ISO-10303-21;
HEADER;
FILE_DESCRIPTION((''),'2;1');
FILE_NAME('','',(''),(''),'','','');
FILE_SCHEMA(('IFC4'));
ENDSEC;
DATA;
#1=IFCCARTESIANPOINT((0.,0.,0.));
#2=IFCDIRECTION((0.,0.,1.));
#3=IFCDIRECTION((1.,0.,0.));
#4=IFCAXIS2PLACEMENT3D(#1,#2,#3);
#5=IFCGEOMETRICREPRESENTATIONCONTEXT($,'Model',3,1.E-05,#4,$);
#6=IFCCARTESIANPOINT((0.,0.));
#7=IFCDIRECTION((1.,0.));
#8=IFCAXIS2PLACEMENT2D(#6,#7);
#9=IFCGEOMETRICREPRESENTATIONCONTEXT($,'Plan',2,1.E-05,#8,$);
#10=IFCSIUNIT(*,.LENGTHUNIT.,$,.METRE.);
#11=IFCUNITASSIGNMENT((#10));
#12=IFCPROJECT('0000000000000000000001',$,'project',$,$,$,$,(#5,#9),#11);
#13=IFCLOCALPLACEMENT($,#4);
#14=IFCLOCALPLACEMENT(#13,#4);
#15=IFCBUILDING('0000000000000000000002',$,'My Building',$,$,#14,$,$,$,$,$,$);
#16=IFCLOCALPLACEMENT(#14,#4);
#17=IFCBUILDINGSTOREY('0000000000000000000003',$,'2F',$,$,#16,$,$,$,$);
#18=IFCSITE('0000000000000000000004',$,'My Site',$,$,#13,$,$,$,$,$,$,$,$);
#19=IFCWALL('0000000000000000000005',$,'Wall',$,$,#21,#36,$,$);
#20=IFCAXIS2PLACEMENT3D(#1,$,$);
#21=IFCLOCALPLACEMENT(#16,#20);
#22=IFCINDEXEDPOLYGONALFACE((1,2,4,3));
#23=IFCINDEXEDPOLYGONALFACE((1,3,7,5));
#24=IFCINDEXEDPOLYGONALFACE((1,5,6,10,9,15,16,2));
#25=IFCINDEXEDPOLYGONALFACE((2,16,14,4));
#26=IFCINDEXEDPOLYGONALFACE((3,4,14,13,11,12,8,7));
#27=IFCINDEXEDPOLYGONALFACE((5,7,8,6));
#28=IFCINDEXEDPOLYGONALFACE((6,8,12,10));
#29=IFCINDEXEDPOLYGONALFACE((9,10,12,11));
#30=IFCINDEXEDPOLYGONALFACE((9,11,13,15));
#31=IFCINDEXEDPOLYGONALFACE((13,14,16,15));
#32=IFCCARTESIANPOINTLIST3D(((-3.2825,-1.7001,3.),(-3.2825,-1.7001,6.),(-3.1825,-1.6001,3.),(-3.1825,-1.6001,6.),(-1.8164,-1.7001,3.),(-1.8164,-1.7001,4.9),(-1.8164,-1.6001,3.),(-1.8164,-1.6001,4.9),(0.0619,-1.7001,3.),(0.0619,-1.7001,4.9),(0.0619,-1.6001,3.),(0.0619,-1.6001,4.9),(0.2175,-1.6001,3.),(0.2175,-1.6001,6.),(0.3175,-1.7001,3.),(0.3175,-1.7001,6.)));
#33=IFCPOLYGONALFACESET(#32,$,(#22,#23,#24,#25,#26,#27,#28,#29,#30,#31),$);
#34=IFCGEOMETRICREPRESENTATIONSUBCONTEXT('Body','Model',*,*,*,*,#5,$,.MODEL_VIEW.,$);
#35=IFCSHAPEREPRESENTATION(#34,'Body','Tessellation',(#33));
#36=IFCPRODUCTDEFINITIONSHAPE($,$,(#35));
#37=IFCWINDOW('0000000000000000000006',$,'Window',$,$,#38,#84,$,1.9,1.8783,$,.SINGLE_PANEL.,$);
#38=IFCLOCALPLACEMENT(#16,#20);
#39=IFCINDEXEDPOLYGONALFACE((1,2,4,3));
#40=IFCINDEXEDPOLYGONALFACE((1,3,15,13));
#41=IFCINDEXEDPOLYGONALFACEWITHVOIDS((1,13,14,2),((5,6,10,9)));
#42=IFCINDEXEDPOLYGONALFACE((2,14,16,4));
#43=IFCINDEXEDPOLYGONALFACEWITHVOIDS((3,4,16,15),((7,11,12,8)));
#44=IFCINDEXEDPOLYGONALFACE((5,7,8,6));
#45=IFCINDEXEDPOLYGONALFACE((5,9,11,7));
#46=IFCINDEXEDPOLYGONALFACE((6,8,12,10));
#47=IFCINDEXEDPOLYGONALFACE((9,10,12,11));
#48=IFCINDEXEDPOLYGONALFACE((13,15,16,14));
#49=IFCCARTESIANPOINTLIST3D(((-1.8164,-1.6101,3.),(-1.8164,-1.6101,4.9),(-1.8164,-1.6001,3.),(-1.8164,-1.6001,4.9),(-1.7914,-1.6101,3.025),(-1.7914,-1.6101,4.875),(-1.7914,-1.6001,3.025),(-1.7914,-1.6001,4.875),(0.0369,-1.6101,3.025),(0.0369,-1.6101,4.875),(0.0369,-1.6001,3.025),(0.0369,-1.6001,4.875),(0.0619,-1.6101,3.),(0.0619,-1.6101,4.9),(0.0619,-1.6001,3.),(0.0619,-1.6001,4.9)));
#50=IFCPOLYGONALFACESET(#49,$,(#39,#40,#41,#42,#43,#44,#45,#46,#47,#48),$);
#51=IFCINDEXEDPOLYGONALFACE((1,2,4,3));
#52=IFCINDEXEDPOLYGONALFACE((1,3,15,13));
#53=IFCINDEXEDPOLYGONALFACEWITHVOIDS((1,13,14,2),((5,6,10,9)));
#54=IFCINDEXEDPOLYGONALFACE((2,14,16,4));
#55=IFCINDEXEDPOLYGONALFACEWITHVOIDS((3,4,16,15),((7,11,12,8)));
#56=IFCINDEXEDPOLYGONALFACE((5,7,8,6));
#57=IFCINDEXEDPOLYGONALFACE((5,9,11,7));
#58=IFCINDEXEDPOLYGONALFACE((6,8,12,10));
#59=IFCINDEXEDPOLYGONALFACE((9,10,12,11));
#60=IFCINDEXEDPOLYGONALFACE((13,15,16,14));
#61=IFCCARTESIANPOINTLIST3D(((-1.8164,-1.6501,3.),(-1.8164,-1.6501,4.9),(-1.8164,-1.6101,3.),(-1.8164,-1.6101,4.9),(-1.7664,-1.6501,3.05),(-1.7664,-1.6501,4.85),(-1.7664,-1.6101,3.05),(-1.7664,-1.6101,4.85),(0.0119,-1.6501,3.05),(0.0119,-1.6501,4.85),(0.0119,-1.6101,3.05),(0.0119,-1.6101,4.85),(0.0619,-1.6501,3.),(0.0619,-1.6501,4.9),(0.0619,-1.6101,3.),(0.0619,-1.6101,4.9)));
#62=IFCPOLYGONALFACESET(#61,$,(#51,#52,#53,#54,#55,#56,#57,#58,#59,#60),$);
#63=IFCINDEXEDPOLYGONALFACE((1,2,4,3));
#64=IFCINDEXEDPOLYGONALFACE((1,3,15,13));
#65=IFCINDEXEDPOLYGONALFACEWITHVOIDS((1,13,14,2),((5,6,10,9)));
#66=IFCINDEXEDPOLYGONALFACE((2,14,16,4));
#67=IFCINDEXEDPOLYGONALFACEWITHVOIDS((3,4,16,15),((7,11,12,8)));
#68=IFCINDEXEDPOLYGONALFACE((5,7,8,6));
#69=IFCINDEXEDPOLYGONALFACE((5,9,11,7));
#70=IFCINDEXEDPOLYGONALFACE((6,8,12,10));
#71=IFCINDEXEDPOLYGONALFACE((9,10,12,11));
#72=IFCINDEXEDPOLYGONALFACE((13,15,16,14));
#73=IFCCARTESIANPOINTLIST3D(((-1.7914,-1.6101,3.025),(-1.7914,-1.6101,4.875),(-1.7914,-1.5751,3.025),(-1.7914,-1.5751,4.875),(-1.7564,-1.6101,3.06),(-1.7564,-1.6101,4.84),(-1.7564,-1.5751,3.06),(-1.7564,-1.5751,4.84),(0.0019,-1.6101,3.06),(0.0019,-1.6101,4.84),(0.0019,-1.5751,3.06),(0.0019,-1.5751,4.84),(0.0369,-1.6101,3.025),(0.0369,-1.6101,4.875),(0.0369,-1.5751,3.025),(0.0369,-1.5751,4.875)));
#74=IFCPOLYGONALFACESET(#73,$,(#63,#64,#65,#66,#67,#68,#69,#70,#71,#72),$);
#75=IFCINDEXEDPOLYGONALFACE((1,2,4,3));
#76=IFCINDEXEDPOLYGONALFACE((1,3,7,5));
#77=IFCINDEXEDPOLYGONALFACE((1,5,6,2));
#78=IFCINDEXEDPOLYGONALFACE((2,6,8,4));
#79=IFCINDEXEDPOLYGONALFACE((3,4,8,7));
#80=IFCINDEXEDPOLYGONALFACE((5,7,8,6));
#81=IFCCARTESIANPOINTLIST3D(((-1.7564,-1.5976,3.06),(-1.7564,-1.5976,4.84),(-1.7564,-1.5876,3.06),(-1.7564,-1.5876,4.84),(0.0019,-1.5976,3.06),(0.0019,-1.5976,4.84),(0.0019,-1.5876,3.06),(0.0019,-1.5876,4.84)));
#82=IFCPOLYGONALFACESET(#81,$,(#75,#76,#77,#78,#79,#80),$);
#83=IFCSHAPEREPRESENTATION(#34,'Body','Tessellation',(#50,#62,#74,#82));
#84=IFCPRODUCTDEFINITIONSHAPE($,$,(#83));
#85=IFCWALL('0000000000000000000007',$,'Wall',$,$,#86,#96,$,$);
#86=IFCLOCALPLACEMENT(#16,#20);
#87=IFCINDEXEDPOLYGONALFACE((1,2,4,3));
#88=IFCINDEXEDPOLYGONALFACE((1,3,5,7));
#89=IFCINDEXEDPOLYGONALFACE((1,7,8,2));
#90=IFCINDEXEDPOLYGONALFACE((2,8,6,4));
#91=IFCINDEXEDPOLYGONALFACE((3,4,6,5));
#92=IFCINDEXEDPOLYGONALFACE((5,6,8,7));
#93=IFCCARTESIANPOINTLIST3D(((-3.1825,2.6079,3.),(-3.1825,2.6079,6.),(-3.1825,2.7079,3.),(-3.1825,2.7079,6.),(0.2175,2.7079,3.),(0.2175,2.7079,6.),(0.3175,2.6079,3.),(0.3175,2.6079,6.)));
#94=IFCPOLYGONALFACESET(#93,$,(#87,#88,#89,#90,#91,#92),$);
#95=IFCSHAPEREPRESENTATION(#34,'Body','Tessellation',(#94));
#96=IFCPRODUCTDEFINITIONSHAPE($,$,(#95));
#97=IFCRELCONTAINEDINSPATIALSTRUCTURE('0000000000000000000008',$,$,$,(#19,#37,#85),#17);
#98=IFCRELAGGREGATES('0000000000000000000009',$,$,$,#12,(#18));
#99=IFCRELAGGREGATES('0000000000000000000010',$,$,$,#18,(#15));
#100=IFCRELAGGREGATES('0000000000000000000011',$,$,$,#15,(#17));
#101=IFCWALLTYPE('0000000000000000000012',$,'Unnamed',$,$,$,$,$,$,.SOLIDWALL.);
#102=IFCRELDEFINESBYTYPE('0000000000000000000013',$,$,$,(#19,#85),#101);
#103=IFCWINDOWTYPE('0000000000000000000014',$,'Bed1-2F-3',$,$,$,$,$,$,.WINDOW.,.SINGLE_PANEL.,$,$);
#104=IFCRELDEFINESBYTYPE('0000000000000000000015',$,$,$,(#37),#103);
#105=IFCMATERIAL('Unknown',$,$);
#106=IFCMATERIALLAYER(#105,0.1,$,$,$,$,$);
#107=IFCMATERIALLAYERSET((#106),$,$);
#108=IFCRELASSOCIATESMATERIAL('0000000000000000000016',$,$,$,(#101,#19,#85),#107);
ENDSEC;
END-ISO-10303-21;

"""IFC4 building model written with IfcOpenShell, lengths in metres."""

from ifc_helpers import new_model, entity, si_unit, frame, origin_with_axes, origin_2d_with_axis, place, context, subcontext, project, spatial, line, indexed_curve, outline, extrude, shape, source, transform, mapped, material, layer, layer_set, layer_usage, type_object, type_shapes, element, fill, save


model = new_model("IFC4")

# Units and contexts
model_context = context("Model", 3, precision=1e-05, world=origin_with_axes())
plan_context = context("Plan", 2, precision=1e-05, world=origin_2d_with_axis())
body_context_1 = subcontext(model_context, "Body", "Model", "MODEL_VIEW")
body_context_2 = subcontext(plan_context, "Body", "Plan", "PLAN_VIEW")
ifc_project = project(units=[si_unit("LENGTHUNIT", "METRE")], contexts=[model_context, plan_context])

# Site, building, storey
site_placement = place(None, origin_with_axes())
site = spatial("IfcSite", under=ifc_project, at=site_placement, Name="My Site")
building_placement = place(site_placement, origin_with_axes())
building = spatial("IfcBuilding", under=site, at=building_placement, Name="My Building")
storey_placement = place(building_placement, origin_with_axes())
storey = spatial("IfcBuildingStorey", under=building, at=storey_placement, Name="2F")

# Shared definitions
ifc_material = material(Name="Unknown")

# Shared definitions
ifc_layer = layer(ifc_material, 0.1)
ifc_layer_set = layer_set([ifc_layer])
wall_type = type_object("IfcWallType", Name="Unnamed", PredefinedType="SOLIDWALL", material=ifc_layer_set)

# Wall, opening, window
ifc_layer_usage_1 = layer_usage(ifc_layer_set, "AXIS2", "POSITIVE", 0.0)
wall_1_placement = place(storey_placement, frame((-3.1825, -1.7001, 3.0), z_axis=(0.0, 0.0, 1.0), x_axis=(1.0, 0.0, 0.0)))
wall_1 = element("IfcWall", 1, at=wall_1_placement, inside=storey, type_object=wall_type, material=ifc_layer_usage_1, Name="Wall", context=body_context_1, shape_type="SweptSolid", body=[
    extrude(outline(indexed_curve([(-0.1, 0.0), (0.0, 0.1), (3.4, 0.1), (3.5, 0.0)], segments=[line(1, 2, 3, 4, 1)])), origin_with_axes(), (0.0, 0.0, 1.0), 3.0),
])
shared_shape_1 = source(origin_with_axes(), body_context_1, "Body", "SweptSolid", [
    extrude(outline(indexed_curve([(0.0, 0.0), (1.8783, 0.0), (1.8783, 1.9), (0.0, 1.9)], segments=[line(1, 2, 3, 4, 1)])), frame((0.0, -0.6, 0.0), z_axis=(0.0, -1.0, 0.0), x_axis=(1.0, 0.0, 0.0)), (0.0, 0.0, -1.0), 1.2),
])
opening_1_placement = place(wall_1_placement, frame((1.3661, 0.0, 0.0), z_axis=(0.0, 0.0, 1.0), x_axis=(1.0, 0.0, 0.0)))
opening_1 = element("IfcOpeningElement", 2, at=opening_1_placement, cuts=wall_1, PredefinedType="OPENING", context=body_context_1, shape_type="MappedRepresentation", body=[
    mapped(shared_shape_1, transform((0.0, 0.0, 0.0), x_axis=(1.0, 0.0, 0.0), y_axis=(0.0, 1.0, 0.0), z_axis=(0.0, 0.0, 1.0), scale=1.0)),
])
window_type_1 = type_object("IfcWindowType", Name="Bed1-2F-3", PartitioningType="SINGLE_PANEL", PredefinedType="WINDOW")
shared_shape_2 = source(origin_with_axes(), body_context_1, "Body", "SweptSolid", [
    extrude(outline(indexed_curve([(0.0, 0.0), (1.8783, 0.0), (1.8783, 1.9), (0.0, 1.9)], segments=[line(1, 2, 3, 4, 1)]), holes=[indexed_curve([(0.025, 0.025), (1.8533, 0.025), (1.8533, 1.875), (0.025, 1.875)], segments=[line(1, 2, 3, 4, 1)])]), frame((0.0, 0.09, 0.0), z_axis=(0.0, -1.0, 0.0), x_axis=(1.0, 0.0, 0.0)), (0.0, 0.0, -1.0), 0.01),
    extrude(outline(indexed_curve([(0.0, 0.0), (1.8783, 0.0), (1.8783, 1.9), (0.0, 1.9)], segments=[line(1, 2, 3, 4, 1)]), holes=[indexed_curve([(0.05, 0.05), (1.8283, 0.05), (1.8283, 1.85), (0.05, 1.85)], segments=[line(1, 2, 3, 4, 1)])]), frame((0.0, 0.05, 0.0), z_axis=(0.0, -1.0, 0.0), x_axis=(1.0, 0.0, 0.0)), (0.0, 0.0, -1.0), 0.04),
    extrude(outline(indexed_curve([(0.0, 0.0), (1.8283, 0.0), (1.8283, 1.85), (0.0, 1.85)], segments=[line(1, 2, 3, 4, 1)]), holes=[indexed_curve([(0.035, 0.035), (1.7933, 0.035), (1.7933, 1.815), (0.035, 1.815)], segments=[line(1, 2, 3, 4, 1)])]), frame((0.025, 0.09, 0.025), z_axis=(0.0, -1.0, 0.0), x_axis=(1.0, 0.0, 0.0)), (0.0, 0.0, -1.0), 0.035),
    extrude(outline(indexed_curve([(0.035, 0.035), (1.7933, 0.035), (1.7933, 1.815), (0.035, 1.815)], segments=[line(1, 2, 3, 4, 1)])), frame((0.025, 0.1025, 0.025), z_axis=(0.0, -1.0, 0.0), x_axis=(1.0, 0.0, 0.0)), (0.0, 0.0, -1.0), 0.01),
])
shared_shape_3 = source(origin_with_axes(), body_context_2, "Body", "Curve2D", [
    entity("IfcIndexedPolyCurve", entity("IfcCartesianPointList2D", [[0.05, 0.05], [1.8283, 0.05]])),
    entity("IfcIndexedPolyCurve", entity("IfcCartesianPointList2D", [[0.0, 0.1], [0.025, 0.1], [0.025, 0.09], [0.05, 0.09], [0.05, 0.05], [0.0, 0.05]]), [entity("IfcLineIndex", [1, 2, 3, 4, 5, 6, 1])]),
    entity("IfcIndexedPolyCurve", entity("IfcCartesianPointList2D", [[1.8783, 0.1], [1.8533, 0.1], [1.8533, 0.09], [1.8283, 0.09], [1.8283, 0.05], [1.8783, 0.05]]), [entity("IfcLineIndex", [1, 2, 3, 4, 5, 6, 1])]),
    entity("IfcIndexedPolyCurve", entity("IfcCartesianPointList2D", [[0.025, 0.09], [0.06, 0.09], [0.06, 0.125], [0.025, 0.125]]), [entity("IfcLineIndex", [1, 2, 3, 4, 1])]),
    entity("IfcIndexedPolyCurve", entity("IfcCartesianPointList2D", [[1.8533, 0.09], [1.8183, 0.09], [1.8183, 0.125], [1.8533, 0.125]]), [entity("IfcLineIndex", [1, 2, 3, 4, 1])]),
    entity("IfcIndexedPolyCurve", entity("IfcCartesianPointList2D", [[0.06, 0.09], [1.8183, 0.09]])),
    entity("IfcIndexedPolyCurve", entity("IfcCartesianPointList2D", [[0.06, 0.125], [1.8183, 0.125]])),
    entity("IfcIndexedPolyCurve", entity("IfcCartesianPointList2D", [[0.06, 0.1075], [1.8183, 0.1075]])),
])
type_shapes(window_type_1, [shared_shape_2, shared_shape_3])
window_1_placement = place(opening_1_placement, frame((0.0, 0.0, 0.0), z_axis=(0.0, 0.0, 1.0), x_axis=(1.0, 0.0, 0.0)))
window_1 = element("IfcWindow", 3, at=window_1_placement, inside=storey, type_object=window_type_1, Name="Window", OverallHeight=1.9, OverallWidth=1.8783, PartitioningType="SINGLE_PANEL", shapes=[
    shape(body_context_1, "Body", "MappedRepresentation", [mapped(shared_shape_2, transform((0.0, 0.0, 0.0), x_axis=(1.0, 0.0, 0.0), y_axis=(0.0, 1.0, 0.0), z_axis=(0.0, 0.0, 1.0), scale=1.0))]),
    shape(body_context_2, "Body", "MappedRepresentation", [mapped(shared_shape_3, transform((0.0, 0.0, 0.0), x_axis=(1.0, 0.0, 0.0), y_axis=(0.0, 1.0, 0.0), z_axis=(0.0, 0.0, 1.0), scale=1.0))]),
])
fill(opening_1, window_1)

# Wall
ifc_layer_usage_2 = layer_usage(ifc_layer_set, "AXIS2", "POSITIVE", 0.0)
wall_2_placement = place(storey_placement, frame((0.3175, 2.7079, 3.0), z_axis=(0.0, 0.0, 1.0), x_axis=(-1.0, 0.0, 0.0)))
element("IfcWall", 4, at=wall_2_placement, inside=storey, type_object=wall_type, material=ifc_layer_usage_2, Name="Wall", context=body_context_1, shape_type="SweptSolid", body=[
    extrude(outline(indexed_curve([(0.1, 0.0), (0.0, 0.1), (3.5, 0.1), (3.5, 0.0)], segments=[line(1, 2, 3, 4, 1)])), origin_with_axes(), (0.0, 0.0, 1.0), 3.0),
])

save(model, "model.ifc")
